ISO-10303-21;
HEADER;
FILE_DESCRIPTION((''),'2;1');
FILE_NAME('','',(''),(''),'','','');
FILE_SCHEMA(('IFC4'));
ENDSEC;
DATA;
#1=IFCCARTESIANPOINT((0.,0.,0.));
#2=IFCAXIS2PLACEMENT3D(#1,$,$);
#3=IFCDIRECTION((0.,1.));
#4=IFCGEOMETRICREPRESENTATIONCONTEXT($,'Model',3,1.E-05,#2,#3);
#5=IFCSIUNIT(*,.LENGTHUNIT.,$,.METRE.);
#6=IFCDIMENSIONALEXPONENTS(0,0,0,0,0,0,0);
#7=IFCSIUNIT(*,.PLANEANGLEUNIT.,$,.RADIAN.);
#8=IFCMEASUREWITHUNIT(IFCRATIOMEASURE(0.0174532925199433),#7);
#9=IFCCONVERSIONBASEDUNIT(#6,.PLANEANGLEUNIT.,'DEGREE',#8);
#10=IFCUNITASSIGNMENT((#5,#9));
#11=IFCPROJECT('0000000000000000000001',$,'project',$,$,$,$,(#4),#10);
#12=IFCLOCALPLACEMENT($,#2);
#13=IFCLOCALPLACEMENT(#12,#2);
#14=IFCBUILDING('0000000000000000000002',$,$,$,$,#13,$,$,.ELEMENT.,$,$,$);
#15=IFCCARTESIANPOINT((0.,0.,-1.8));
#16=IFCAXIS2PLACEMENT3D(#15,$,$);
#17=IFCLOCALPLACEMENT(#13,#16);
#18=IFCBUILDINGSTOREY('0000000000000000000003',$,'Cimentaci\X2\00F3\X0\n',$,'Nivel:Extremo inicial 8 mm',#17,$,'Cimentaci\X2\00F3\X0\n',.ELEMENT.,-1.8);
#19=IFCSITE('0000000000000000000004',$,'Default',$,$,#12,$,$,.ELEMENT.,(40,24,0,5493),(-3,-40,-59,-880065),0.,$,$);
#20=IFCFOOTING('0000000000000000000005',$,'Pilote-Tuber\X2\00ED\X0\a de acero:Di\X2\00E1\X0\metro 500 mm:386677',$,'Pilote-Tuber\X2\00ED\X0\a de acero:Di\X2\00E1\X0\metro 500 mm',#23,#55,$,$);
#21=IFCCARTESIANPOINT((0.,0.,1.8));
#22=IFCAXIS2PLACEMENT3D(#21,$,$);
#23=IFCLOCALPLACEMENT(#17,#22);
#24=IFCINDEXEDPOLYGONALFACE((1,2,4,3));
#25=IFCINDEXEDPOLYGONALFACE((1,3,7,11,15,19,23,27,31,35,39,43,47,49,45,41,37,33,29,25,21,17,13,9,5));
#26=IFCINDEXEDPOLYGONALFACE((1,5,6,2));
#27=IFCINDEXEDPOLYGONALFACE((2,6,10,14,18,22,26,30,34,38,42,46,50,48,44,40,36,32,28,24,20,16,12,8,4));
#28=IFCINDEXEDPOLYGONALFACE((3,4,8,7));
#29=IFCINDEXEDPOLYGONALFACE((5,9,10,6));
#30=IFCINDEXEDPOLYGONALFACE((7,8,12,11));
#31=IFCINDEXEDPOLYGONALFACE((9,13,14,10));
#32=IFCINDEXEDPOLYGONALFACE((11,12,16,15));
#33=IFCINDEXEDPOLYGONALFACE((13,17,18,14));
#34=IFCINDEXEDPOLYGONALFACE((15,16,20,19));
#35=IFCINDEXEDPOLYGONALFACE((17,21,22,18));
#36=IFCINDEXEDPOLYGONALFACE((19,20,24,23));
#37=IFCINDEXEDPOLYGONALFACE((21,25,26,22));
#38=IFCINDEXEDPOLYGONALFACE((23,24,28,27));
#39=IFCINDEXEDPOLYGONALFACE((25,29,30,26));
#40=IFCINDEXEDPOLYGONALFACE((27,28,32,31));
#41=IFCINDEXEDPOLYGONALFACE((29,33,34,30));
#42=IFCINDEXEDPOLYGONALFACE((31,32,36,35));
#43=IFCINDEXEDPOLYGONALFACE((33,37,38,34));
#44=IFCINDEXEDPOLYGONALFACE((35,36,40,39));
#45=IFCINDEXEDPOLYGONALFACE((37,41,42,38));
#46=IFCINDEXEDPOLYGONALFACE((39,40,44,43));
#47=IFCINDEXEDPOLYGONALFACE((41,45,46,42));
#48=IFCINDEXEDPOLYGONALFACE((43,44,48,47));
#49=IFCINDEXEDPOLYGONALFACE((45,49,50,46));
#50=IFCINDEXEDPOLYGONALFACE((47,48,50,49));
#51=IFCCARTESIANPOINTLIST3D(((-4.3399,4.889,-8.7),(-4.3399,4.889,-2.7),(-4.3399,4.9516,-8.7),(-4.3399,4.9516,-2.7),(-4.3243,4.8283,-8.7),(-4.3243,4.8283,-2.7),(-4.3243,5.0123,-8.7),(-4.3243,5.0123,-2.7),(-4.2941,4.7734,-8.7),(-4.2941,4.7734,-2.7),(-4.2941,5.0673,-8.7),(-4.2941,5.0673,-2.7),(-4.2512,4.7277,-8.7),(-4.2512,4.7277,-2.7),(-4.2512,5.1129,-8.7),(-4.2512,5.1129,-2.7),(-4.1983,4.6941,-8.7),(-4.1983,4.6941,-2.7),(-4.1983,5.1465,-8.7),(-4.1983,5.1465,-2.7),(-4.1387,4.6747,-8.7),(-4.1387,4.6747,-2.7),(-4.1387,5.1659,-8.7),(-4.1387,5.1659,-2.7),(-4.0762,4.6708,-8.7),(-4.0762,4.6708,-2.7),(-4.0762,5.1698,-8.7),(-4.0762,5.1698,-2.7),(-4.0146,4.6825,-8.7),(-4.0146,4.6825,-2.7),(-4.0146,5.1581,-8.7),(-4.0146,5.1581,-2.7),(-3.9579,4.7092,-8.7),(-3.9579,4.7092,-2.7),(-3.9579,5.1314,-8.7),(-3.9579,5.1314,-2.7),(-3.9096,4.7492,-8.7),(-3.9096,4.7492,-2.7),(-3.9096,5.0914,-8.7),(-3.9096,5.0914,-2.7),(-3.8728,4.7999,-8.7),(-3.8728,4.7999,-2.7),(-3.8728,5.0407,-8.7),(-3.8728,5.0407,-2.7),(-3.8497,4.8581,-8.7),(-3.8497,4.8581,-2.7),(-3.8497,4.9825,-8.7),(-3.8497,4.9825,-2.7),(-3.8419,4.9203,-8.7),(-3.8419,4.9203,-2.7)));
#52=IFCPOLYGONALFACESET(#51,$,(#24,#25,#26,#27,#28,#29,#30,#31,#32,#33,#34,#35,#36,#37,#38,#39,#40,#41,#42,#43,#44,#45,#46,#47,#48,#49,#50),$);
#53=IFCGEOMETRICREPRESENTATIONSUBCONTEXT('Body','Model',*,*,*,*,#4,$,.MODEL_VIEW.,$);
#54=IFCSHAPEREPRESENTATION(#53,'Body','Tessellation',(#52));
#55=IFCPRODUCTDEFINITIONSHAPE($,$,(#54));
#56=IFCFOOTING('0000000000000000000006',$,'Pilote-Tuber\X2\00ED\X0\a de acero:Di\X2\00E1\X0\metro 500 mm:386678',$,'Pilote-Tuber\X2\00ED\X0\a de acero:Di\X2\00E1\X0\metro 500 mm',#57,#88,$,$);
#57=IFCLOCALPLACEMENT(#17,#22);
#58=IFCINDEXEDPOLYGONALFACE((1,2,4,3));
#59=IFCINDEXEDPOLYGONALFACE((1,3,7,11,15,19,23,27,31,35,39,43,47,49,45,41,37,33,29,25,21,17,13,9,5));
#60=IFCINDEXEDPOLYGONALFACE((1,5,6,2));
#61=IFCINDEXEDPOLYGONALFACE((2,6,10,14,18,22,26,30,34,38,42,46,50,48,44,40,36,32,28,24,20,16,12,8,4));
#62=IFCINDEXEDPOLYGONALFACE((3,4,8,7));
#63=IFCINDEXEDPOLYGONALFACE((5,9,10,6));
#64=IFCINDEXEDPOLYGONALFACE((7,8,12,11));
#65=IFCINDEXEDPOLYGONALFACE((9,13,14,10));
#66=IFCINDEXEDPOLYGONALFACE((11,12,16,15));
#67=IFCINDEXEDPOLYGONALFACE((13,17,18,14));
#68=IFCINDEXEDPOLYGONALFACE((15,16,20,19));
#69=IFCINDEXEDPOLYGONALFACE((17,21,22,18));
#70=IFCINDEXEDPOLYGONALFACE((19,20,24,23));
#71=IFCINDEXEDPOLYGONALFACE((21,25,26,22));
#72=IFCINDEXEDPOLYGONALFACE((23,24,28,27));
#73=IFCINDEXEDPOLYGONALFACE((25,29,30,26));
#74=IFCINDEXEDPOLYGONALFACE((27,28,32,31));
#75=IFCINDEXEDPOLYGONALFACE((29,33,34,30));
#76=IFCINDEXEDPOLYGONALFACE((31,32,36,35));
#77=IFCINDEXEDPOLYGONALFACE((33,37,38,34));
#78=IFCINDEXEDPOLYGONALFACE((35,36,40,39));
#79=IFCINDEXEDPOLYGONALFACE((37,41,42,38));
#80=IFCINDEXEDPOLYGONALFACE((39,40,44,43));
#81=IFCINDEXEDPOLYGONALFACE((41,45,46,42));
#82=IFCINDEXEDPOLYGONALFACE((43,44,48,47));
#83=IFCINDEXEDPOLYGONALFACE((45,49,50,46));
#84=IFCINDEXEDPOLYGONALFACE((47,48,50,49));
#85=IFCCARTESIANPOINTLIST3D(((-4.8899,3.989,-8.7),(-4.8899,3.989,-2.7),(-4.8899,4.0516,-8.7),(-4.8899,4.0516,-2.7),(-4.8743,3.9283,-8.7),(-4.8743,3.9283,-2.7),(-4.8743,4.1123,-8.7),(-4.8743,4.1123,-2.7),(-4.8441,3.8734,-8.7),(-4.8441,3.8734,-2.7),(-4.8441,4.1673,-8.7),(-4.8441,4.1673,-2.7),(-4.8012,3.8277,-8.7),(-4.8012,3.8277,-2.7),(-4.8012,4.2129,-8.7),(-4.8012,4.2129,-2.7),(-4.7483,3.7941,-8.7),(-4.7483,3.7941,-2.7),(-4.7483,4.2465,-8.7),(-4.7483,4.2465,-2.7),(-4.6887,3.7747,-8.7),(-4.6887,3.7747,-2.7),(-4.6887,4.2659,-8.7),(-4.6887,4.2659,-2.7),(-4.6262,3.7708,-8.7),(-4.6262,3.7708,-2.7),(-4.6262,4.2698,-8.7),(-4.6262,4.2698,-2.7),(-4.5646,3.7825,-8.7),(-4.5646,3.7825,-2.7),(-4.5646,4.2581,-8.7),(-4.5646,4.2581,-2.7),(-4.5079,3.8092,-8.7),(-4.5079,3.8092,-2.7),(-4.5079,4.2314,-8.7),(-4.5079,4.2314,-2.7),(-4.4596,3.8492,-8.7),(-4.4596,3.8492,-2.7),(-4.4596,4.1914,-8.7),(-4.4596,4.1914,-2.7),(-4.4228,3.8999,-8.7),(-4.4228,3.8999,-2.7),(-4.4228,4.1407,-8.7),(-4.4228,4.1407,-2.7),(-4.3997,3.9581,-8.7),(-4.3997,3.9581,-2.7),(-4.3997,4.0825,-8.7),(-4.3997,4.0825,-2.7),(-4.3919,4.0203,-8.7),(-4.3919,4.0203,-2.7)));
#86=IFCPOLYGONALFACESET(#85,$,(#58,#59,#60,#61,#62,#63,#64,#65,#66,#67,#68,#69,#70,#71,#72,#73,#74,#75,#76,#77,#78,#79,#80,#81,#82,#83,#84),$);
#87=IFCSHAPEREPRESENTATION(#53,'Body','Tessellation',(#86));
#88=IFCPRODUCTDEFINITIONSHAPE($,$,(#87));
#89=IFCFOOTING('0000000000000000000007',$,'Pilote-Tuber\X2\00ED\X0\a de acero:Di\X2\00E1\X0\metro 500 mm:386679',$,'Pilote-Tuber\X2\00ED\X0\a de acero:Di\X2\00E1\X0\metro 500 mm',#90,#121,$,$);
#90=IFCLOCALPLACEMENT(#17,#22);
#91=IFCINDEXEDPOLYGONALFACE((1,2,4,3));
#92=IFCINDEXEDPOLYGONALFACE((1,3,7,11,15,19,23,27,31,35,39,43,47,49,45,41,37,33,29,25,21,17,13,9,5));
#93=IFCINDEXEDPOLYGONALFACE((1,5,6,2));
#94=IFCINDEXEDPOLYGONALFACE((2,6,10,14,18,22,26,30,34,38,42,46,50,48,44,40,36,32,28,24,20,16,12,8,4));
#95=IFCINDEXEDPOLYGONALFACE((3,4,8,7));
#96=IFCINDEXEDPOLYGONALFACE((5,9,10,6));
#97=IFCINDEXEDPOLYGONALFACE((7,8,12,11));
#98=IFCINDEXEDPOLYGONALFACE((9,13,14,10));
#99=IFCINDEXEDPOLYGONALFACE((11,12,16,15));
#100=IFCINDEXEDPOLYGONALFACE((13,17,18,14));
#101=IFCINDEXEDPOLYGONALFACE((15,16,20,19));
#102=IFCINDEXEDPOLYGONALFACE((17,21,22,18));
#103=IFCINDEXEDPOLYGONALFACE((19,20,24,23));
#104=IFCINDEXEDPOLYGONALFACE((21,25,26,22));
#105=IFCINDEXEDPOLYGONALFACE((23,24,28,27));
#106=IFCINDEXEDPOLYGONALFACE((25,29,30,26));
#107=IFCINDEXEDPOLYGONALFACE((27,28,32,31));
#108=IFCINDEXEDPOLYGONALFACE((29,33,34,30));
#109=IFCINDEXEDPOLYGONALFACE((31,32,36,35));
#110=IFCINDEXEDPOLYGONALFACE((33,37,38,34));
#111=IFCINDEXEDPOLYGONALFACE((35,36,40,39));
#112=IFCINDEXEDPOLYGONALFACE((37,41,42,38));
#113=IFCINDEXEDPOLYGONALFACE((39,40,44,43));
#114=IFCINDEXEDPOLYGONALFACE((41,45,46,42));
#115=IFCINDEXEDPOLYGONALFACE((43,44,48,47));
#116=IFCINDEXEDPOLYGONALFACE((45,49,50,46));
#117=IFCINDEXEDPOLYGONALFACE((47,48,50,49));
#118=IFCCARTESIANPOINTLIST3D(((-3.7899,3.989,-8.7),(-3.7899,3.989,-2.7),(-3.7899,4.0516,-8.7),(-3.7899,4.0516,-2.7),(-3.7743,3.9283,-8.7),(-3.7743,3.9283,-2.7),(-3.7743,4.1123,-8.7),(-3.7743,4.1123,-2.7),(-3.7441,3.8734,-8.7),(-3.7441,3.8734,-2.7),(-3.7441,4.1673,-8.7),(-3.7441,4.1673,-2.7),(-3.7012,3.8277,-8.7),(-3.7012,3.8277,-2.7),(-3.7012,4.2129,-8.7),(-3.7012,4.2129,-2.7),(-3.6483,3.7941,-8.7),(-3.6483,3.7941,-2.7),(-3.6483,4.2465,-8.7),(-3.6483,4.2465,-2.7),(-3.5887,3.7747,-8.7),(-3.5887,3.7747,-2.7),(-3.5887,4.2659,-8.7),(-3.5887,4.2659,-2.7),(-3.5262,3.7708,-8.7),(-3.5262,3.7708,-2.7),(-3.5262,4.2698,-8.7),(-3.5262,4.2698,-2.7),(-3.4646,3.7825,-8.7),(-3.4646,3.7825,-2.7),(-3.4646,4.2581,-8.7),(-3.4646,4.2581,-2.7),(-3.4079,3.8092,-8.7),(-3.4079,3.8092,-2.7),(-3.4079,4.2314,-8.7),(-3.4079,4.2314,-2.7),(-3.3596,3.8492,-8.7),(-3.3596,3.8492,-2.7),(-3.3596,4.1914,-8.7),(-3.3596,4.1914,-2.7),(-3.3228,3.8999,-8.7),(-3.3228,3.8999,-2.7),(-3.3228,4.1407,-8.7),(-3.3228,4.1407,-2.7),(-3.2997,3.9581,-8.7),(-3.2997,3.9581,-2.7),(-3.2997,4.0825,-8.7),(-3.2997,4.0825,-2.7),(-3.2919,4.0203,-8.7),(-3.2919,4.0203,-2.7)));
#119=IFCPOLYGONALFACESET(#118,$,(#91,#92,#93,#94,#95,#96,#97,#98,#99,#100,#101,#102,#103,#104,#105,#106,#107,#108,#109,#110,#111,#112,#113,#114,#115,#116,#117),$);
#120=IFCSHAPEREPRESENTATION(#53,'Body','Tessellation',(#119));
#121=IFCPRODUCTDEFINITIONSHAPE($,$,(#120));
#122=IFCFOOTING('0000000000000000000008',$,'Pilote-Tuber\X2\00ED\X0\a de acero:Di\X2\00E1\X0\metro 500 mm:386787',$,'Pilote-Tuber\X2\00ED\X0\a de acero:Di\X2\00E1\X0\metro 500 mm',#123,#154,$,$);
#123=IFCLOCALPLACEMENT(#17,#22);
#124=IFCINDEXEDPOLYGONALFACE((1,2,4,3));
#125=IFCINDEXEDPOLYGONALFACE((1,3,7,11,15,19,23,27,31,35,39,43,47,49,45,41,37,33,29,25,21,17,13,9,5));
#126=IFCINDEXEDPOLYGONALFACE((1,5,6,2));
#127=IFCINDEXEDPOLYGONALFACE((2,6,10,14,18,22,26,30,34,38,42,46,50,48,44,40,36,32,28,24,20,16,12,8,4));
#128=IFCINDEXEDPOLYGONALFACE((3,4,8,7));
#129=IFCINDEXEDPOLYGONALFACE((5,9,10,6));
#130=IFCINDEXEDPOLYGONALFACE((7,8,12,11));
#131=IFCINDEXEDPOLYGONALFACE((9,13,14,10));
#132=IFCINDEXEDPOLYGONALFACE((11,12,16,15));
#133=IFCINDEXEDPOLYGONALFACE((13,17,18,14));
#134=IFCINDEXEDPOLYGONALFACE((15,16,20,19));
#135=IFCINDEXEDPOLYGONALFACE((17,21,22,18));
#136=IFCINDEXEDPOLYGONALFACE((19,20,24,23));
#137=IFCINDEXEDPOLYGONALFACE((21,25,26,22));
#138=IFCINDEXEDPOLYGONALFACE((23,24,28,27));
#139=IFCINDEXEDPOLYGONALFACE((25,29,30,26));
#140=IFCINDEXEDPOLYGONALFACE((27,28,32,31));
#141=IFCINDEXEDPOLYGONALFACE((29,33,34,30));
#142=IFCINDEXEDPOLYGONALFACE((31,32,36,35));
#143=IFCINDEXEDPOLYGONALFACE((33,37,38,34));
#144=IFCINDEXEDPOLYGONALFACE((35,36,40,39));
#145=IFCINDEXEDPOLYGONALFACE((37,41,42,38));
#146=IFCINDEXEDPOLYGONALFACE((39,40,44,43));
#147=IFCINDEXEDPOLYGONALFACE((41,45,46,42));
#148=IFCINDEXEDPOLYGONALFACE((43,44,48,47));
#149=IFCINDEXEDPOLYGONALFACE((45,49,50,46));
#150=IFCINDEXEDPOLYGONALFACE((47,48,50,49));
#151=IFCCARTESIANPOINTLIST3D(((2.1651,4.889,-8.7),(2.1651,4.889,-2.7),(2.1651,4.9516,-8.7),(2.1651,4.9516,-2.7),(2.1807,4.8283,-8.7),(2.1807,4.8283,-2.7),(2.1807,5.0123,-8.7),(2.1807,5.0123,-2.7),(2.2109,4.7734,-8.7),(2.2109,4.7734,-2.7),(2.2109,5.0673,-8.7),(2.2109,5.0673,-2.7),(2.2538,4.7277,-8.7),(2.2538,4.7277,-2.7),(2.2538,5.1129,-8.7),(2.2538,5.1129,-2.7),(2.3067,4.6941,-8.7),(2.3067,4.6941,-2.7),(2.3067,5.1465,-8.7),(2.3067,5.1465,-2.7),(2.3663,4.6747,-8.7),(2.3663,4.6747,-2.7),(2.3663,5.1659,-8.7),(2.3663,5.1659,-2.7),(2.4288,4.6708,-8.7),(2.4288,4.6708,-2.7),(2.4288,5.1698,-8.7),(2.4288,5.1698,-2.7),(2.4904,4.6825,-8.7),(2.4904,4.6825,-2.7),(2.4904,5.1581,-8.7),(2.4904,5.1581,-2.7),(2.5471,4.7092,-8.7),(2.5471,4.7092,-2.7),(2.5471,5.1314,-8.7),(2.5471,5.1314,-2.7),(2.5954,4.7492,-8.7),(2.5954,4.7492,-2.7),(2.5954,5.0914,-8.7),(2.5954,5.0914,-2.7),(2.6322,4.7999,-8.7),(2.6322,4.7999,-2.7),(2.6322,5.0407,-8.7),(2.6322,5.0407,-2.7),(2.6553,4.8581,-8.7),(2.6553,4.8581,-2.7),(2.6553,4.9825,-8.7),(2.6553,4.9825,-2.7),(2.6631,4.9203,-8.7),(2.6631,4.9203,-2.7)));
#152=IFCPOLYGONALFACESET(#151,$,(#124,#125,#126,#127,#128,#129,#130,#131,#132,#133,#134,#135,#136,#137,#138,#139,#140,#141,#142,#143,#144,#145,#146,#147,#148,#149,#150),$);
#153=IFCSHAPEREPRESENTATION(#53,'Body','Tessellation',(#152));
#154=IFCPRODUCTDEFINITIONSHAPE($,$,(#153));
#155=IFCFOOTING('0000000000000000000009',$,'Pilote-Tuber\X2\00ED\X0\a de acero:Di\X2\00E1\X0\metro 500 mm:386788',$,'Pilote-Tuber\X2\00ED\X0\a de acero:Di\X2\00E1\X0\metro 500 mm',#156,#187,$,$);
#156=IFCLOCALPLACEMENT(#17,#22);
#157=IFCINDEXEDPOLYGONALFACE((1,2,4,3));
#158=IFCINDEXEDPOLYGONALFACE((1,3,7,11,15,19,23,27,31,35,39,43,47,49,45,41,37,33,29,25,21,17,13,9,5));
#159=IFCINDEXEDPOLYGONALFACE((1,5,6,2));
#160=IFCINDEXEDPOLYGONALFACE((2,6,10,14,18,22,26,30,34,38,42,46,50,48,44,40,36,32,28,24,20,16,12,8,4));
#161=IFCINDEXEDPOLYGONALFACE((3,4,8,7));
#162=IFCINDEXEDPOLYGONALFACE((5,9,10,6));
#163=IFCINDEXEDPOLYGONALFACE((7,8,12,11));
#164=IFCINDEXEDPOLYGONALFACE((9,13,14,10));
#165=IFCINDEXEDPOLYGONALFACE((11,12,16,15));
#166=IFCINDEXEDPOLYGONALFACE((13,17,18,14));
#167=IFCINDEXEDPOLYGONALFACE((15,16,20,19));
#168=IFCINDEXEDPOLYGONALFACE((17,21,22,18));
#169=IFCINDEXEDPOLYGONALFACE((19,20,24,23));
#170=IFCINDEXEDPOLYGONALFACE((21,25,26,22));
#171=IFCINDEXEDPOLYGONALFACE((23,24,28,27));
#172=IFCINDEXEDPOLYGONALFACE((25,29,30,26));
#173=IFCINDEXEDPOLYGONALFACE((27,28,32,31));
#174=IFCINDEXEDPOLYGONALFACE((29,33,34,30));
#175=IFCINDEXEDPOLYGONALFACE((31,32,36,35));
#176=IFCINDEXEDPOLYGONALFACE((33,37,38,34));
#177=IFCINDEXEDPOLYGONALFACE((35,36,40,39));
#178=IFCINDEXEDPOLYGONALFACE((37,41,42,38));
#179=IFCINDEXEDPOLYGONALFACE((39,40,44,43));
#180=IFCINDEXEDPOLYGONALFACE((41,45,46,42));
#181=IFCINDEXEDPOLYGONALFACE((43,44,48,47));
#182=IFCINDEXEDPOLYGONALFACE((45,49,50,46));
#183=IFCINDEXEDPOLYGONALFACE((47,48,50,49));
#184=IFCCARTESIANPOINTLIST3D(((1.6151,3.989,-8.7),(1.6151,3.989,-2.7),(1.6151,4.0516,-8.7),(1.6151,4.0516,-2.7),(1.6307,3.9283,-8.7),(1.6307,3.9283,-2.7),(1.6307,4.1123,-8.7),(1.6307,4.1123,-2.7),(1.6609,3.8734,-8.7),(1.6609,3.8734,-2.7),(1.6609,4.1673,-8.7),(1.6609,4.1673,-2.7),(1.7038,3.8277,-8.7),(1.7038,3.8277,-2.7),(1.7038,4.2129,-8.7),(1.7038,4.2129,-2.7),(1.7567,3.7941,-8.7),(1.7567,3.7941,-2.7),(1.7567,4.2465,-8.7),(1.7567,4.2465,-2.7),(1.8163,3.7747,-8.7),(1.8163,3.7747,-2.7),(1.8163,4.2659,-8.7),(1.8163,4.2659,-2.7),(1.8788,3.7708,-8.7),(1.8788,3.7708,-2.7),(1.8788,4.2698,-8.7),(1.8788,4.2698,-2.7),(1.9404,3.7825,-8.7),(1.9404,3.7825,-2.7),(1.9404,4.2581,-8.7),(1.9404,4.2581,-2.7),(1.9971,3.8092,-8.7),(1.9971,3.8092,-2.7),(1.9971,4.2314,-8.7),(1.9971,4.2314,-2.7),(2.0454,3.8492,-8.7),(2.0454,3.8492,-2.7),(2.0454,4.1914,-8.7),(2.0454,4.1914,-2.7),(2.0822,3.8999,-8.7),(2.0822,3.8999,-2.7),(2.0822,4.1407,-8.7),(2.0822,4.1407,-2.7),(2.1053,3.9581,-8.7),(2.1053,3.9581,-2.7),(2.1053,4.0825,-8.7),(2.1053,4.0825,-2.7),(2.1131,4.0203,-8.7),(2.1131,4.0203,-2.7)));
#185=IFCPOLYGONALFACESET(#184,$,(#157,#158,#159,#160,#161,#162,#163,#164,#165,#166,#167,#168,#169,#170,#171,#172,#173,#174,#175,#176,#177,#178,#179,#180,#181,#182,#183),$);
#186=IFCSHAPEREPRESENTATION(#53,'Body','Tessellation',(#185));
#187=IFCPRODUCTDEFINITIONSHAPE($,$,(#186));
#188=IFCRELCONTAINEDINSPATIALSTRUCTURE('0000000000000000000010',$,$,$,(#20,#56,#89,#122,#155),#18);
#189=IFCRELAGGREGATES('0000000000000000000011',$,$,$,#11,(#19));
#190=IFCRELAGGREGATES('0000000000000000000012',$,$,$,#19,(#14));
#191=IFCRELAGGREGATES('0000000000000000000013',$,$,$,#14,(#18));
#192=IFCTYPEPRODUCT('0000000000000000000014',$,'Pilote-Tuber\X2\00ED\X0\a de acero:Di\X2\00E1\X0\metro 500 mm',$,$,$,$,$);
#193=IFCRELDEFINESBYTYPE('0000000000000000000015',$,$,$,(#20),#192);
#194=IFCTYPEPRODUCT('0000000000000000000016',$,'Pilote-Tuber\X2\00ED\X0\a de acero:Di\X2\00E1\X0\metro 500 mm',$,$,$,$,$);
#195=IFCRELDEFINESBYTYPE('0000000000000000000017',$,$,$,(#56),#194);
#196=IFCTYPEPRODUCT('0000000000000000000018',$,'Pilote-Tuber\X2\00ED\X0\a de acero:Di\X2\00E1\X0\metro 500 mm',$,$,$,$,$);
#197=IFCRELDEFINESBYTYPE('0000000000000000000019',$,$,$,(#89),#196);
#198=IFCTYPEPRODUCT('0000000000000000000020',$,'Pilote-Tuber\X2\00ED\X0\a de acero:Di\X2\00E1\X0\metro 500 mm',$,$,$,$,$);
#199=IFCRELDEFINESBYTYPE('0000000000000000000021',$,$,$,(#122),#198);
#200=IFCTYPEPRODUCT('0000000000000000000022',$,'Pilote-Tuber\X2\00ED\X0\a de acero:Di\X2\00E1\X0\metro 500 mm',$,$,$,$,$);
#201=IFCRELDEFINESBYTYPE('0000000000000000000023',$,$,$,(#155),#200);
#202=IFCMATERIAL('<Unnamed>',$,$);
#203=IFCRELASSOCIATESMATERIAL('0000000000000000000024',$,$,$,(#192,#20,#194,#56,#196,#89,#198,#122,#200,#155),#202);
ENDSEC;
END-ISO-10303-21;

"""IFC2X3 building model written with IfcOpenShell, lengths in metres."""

from ifc_helpers import new_model, entity, si_unit, converted_unit, direction, frame, frame_2d, origin, origin_2d_with_axis, place, context, subcontext, project, spatial, circle, extrude, source, transform, mapped, material, type_object, type_shapes, element, save


model = new_model("IFC2X3")

# Units and contexts
model_context = context("Model", 3, precision=1e-05, world=origin(), true_north=direction((0.0, 1.0)))
body_context = subcontext(model_context, "Body", "Model", "MODEL_VIEW")
ifc_project = project(units=[si_unit("LENGTHUNIT", "METRE"), converted_unit("PLANEANGLEUNIT", "DEGREE", entity("IfcRatioMeasure", 0.0174532925199433), si_unit("PLANEANGLEUNIT", "RADIAN"), dimensions=[0, 0, 0, 0, 0, 0, 0])], contexts=[model_context])

# Site, building, storey
site_placement = place(None, origin())
site = spatial("IfcSite", under=ifc_project, at=site_placement, Name="Default", CompositionType="ELEMENT", RefLatitude=(40, 24, 0, 5493), RefLongitude=(-3, -40, -59, -880065), RefElevation=0.0)
building_placement = place(site_placement, origin())
building = spatial("IfcBuilding", under=site, at=building_placement, CompositionType="ELEMENT")
storey_placement = place(building_placement, frame((0.0, 0.0, -1.8)))
storey = spatial("IfcBuildingStorey", under=building, at=storey_placement, Name="Cimentación", ObjectType="Nivel:Extremo inicial 8 mm", LongName="Cimentación", CompositionType="ELEMENT", Elevation=-1.8)

# Footings
ifc_material_1 = material(Name="<Unnamed>")
type_product_1 = type_object("IfcTypeProduct", Name="Pilote-Tubería de acero:Diámetro 500 mm", material=ifc_material_1)
shared_shape_1 = source(origin(), body_context, "Body", "SweptSolid", [
    extrude(circle(Radius=0.25, at=origin_2d_with_axis()), frame((-4.0919, 4.9203, -8.7)), (0.0, 0.0, 1.0), 6.0),
])
type_shapes(type_product_1, [shared_shape_1])
footing_1_placement = place(storey_placement, frame((0.0, 0.0, 1.8)))
element("IfcFooting", 1, at=footing_1_placement, inside=storey, type_object=type_product_1, material=ifc_material_1, Name="Pilote-Tubería de acero:Diámetro 500 mm:386677", ObjectType="Pilote-Tubería de acero:Diámetro 500 mm", context=body_context, shape_type="MappedRepresentation", body=[
    mapped(shared_shape_1, transform((0.0, 0.0, 0.0), scale=1.0)),
])
type_product_2 = type_object("IfcTypeProduct", Name="Pilote-Tubería de acero:Diámetro 500 mm", material=ifc_material_1)
shared_shape_2 = source(origin(), body_context, "Body", "SweptSolid", [
    extrude(circle(Radius=0.25, at=frame_2d((0.0, 0.0), x_axis=(1.0, 0.0))), frame((-4.6419, 4.0203, -8.7)), (0.0, 0.0, 1.0), 6.0),
])
type_shapes(type_product_2, [shared_shape_2])
footing_2_placement = place(storey_placement, frame((0.0, 0.0, 1.8)))
element("IfcFooting", 2, at=footing_2_placement, inside=storey, type_object=type_product_2, material=ifc_material_1, Name="Pilote-Tubería de acero:Diámetro 500 mm:386678", ObjectType="Pilote-Tubería de acero:Diámetro 500 mm", context=body_context, shape_type="MappedRepresentation", body=[
    mapped(shared_shape_2, transform((0.0, 0.0, 0.0), scale=1.0)),
])
type_product_3 = type_object("IfcTypeProduct", Name="Pilote-Tubería de acero:Diámetro 500 mm", material=ifc_material_1)
shared_shape_3 = source(origin(), body_context, "Body", "SweptSolid", [
    extrude(circle(Radius=0.25, at=frame_2d((0.0, 0.0), x_axis=(1.0, 0.0))), frame((-3.5419, 4.0203, -8.7)), (0.0, 0.0, 1.0), 6.0),
])
type_shapes(type_product_3, [shared_shape_3])
footing_3_placement = place(storey_placement, frame((0.0, 0.0, 1.8)))
element("IfcFooting", 3, at=footing_3_placement, inside=storey, type_object=type_product_3, material=ifc_material_1, Name="Pilote-Tubería de acero:Diámetro 500 mm:386679", ObjectType="Pilote-Tubería de acero:Diámetro 500 mm", context=body_context, shape_type="MappedRepresentation", body=[
    mapped(shared_shape_3, transform((0.0, 0.0, 0.0), scale=1.0)),
])
type_product_4 = type_object("IfcTypeProduct", Name="Pilote-Tubería de acero:Diámetro 500 mm", material=ifc_material_1)
shared_shape_4 = source(origin(), body_context, "Body", "SweptSolid", [
    extrude(circle(Radius=0.25, at=frame_2d((0.0, 0.0), x_axis=(1.0, 0.0))), frame((2.4131, 4.9203, -8.7)), (0.0, 0.0, 1.0), 6.0),
])
type_shapes(type_product_4, [shared_shape_4])
footing_4_placement = place(storey_placement, frame((0.0, 0.0, 1.8)))
element("IfcFooting", 4, at=footing_4_placement, inside=storey, type_object=type_product_4, material=ifc_material_1, Name="Pilote-Tubería de acero:Diámetro 500 mm:386787", ObjectType="Pilote-Tubería de acero:Diámetro 500 mm", context=body_context, shape_type="MappedRepresentation", body=[
    mapped(shared_shape_4, transform((0.0, 0.0, 0.0), scale=1.0)),
])
type_product_5 = type_object("IfcTypeProduct", Name="Pilote-Tubería de acero:Diámetro 500 mm", material=ifc_material_1)
shared_shape_5 = source(origin(), body_context, "Body", "SweptSolid", [
    extrude(circle(Radius=0.25, at=frame_2d((0.0, 0.0), x_axis=(1.0, 0.0))), frame((1.8631, 4.0203, -8.7)), (0.0, 0.0, 1.0), 6.0),
])
type_shapes(type_product_5, [shared_shape_5])
footing_5_placement = place(storey_placement, frame((0.0, 0.0, 1.8)))
element("IfcFooting", 5, at=footing_5_placement, inside=storey, type_object=type_product_5, material=ifc_material_1, Name="Pilote-Tubería de acero:Diámetro 500 mm:386788", ObjectType="Pilote-Tubería de acero:Diámetro 500 mm", context=body_context, shape_type="MappedRepresentation", body=[
    mapped(shared_shape_5, transform((0.0, 0.0, 0.0), scale=1.0)),
])

save(model, "model.ifc")
